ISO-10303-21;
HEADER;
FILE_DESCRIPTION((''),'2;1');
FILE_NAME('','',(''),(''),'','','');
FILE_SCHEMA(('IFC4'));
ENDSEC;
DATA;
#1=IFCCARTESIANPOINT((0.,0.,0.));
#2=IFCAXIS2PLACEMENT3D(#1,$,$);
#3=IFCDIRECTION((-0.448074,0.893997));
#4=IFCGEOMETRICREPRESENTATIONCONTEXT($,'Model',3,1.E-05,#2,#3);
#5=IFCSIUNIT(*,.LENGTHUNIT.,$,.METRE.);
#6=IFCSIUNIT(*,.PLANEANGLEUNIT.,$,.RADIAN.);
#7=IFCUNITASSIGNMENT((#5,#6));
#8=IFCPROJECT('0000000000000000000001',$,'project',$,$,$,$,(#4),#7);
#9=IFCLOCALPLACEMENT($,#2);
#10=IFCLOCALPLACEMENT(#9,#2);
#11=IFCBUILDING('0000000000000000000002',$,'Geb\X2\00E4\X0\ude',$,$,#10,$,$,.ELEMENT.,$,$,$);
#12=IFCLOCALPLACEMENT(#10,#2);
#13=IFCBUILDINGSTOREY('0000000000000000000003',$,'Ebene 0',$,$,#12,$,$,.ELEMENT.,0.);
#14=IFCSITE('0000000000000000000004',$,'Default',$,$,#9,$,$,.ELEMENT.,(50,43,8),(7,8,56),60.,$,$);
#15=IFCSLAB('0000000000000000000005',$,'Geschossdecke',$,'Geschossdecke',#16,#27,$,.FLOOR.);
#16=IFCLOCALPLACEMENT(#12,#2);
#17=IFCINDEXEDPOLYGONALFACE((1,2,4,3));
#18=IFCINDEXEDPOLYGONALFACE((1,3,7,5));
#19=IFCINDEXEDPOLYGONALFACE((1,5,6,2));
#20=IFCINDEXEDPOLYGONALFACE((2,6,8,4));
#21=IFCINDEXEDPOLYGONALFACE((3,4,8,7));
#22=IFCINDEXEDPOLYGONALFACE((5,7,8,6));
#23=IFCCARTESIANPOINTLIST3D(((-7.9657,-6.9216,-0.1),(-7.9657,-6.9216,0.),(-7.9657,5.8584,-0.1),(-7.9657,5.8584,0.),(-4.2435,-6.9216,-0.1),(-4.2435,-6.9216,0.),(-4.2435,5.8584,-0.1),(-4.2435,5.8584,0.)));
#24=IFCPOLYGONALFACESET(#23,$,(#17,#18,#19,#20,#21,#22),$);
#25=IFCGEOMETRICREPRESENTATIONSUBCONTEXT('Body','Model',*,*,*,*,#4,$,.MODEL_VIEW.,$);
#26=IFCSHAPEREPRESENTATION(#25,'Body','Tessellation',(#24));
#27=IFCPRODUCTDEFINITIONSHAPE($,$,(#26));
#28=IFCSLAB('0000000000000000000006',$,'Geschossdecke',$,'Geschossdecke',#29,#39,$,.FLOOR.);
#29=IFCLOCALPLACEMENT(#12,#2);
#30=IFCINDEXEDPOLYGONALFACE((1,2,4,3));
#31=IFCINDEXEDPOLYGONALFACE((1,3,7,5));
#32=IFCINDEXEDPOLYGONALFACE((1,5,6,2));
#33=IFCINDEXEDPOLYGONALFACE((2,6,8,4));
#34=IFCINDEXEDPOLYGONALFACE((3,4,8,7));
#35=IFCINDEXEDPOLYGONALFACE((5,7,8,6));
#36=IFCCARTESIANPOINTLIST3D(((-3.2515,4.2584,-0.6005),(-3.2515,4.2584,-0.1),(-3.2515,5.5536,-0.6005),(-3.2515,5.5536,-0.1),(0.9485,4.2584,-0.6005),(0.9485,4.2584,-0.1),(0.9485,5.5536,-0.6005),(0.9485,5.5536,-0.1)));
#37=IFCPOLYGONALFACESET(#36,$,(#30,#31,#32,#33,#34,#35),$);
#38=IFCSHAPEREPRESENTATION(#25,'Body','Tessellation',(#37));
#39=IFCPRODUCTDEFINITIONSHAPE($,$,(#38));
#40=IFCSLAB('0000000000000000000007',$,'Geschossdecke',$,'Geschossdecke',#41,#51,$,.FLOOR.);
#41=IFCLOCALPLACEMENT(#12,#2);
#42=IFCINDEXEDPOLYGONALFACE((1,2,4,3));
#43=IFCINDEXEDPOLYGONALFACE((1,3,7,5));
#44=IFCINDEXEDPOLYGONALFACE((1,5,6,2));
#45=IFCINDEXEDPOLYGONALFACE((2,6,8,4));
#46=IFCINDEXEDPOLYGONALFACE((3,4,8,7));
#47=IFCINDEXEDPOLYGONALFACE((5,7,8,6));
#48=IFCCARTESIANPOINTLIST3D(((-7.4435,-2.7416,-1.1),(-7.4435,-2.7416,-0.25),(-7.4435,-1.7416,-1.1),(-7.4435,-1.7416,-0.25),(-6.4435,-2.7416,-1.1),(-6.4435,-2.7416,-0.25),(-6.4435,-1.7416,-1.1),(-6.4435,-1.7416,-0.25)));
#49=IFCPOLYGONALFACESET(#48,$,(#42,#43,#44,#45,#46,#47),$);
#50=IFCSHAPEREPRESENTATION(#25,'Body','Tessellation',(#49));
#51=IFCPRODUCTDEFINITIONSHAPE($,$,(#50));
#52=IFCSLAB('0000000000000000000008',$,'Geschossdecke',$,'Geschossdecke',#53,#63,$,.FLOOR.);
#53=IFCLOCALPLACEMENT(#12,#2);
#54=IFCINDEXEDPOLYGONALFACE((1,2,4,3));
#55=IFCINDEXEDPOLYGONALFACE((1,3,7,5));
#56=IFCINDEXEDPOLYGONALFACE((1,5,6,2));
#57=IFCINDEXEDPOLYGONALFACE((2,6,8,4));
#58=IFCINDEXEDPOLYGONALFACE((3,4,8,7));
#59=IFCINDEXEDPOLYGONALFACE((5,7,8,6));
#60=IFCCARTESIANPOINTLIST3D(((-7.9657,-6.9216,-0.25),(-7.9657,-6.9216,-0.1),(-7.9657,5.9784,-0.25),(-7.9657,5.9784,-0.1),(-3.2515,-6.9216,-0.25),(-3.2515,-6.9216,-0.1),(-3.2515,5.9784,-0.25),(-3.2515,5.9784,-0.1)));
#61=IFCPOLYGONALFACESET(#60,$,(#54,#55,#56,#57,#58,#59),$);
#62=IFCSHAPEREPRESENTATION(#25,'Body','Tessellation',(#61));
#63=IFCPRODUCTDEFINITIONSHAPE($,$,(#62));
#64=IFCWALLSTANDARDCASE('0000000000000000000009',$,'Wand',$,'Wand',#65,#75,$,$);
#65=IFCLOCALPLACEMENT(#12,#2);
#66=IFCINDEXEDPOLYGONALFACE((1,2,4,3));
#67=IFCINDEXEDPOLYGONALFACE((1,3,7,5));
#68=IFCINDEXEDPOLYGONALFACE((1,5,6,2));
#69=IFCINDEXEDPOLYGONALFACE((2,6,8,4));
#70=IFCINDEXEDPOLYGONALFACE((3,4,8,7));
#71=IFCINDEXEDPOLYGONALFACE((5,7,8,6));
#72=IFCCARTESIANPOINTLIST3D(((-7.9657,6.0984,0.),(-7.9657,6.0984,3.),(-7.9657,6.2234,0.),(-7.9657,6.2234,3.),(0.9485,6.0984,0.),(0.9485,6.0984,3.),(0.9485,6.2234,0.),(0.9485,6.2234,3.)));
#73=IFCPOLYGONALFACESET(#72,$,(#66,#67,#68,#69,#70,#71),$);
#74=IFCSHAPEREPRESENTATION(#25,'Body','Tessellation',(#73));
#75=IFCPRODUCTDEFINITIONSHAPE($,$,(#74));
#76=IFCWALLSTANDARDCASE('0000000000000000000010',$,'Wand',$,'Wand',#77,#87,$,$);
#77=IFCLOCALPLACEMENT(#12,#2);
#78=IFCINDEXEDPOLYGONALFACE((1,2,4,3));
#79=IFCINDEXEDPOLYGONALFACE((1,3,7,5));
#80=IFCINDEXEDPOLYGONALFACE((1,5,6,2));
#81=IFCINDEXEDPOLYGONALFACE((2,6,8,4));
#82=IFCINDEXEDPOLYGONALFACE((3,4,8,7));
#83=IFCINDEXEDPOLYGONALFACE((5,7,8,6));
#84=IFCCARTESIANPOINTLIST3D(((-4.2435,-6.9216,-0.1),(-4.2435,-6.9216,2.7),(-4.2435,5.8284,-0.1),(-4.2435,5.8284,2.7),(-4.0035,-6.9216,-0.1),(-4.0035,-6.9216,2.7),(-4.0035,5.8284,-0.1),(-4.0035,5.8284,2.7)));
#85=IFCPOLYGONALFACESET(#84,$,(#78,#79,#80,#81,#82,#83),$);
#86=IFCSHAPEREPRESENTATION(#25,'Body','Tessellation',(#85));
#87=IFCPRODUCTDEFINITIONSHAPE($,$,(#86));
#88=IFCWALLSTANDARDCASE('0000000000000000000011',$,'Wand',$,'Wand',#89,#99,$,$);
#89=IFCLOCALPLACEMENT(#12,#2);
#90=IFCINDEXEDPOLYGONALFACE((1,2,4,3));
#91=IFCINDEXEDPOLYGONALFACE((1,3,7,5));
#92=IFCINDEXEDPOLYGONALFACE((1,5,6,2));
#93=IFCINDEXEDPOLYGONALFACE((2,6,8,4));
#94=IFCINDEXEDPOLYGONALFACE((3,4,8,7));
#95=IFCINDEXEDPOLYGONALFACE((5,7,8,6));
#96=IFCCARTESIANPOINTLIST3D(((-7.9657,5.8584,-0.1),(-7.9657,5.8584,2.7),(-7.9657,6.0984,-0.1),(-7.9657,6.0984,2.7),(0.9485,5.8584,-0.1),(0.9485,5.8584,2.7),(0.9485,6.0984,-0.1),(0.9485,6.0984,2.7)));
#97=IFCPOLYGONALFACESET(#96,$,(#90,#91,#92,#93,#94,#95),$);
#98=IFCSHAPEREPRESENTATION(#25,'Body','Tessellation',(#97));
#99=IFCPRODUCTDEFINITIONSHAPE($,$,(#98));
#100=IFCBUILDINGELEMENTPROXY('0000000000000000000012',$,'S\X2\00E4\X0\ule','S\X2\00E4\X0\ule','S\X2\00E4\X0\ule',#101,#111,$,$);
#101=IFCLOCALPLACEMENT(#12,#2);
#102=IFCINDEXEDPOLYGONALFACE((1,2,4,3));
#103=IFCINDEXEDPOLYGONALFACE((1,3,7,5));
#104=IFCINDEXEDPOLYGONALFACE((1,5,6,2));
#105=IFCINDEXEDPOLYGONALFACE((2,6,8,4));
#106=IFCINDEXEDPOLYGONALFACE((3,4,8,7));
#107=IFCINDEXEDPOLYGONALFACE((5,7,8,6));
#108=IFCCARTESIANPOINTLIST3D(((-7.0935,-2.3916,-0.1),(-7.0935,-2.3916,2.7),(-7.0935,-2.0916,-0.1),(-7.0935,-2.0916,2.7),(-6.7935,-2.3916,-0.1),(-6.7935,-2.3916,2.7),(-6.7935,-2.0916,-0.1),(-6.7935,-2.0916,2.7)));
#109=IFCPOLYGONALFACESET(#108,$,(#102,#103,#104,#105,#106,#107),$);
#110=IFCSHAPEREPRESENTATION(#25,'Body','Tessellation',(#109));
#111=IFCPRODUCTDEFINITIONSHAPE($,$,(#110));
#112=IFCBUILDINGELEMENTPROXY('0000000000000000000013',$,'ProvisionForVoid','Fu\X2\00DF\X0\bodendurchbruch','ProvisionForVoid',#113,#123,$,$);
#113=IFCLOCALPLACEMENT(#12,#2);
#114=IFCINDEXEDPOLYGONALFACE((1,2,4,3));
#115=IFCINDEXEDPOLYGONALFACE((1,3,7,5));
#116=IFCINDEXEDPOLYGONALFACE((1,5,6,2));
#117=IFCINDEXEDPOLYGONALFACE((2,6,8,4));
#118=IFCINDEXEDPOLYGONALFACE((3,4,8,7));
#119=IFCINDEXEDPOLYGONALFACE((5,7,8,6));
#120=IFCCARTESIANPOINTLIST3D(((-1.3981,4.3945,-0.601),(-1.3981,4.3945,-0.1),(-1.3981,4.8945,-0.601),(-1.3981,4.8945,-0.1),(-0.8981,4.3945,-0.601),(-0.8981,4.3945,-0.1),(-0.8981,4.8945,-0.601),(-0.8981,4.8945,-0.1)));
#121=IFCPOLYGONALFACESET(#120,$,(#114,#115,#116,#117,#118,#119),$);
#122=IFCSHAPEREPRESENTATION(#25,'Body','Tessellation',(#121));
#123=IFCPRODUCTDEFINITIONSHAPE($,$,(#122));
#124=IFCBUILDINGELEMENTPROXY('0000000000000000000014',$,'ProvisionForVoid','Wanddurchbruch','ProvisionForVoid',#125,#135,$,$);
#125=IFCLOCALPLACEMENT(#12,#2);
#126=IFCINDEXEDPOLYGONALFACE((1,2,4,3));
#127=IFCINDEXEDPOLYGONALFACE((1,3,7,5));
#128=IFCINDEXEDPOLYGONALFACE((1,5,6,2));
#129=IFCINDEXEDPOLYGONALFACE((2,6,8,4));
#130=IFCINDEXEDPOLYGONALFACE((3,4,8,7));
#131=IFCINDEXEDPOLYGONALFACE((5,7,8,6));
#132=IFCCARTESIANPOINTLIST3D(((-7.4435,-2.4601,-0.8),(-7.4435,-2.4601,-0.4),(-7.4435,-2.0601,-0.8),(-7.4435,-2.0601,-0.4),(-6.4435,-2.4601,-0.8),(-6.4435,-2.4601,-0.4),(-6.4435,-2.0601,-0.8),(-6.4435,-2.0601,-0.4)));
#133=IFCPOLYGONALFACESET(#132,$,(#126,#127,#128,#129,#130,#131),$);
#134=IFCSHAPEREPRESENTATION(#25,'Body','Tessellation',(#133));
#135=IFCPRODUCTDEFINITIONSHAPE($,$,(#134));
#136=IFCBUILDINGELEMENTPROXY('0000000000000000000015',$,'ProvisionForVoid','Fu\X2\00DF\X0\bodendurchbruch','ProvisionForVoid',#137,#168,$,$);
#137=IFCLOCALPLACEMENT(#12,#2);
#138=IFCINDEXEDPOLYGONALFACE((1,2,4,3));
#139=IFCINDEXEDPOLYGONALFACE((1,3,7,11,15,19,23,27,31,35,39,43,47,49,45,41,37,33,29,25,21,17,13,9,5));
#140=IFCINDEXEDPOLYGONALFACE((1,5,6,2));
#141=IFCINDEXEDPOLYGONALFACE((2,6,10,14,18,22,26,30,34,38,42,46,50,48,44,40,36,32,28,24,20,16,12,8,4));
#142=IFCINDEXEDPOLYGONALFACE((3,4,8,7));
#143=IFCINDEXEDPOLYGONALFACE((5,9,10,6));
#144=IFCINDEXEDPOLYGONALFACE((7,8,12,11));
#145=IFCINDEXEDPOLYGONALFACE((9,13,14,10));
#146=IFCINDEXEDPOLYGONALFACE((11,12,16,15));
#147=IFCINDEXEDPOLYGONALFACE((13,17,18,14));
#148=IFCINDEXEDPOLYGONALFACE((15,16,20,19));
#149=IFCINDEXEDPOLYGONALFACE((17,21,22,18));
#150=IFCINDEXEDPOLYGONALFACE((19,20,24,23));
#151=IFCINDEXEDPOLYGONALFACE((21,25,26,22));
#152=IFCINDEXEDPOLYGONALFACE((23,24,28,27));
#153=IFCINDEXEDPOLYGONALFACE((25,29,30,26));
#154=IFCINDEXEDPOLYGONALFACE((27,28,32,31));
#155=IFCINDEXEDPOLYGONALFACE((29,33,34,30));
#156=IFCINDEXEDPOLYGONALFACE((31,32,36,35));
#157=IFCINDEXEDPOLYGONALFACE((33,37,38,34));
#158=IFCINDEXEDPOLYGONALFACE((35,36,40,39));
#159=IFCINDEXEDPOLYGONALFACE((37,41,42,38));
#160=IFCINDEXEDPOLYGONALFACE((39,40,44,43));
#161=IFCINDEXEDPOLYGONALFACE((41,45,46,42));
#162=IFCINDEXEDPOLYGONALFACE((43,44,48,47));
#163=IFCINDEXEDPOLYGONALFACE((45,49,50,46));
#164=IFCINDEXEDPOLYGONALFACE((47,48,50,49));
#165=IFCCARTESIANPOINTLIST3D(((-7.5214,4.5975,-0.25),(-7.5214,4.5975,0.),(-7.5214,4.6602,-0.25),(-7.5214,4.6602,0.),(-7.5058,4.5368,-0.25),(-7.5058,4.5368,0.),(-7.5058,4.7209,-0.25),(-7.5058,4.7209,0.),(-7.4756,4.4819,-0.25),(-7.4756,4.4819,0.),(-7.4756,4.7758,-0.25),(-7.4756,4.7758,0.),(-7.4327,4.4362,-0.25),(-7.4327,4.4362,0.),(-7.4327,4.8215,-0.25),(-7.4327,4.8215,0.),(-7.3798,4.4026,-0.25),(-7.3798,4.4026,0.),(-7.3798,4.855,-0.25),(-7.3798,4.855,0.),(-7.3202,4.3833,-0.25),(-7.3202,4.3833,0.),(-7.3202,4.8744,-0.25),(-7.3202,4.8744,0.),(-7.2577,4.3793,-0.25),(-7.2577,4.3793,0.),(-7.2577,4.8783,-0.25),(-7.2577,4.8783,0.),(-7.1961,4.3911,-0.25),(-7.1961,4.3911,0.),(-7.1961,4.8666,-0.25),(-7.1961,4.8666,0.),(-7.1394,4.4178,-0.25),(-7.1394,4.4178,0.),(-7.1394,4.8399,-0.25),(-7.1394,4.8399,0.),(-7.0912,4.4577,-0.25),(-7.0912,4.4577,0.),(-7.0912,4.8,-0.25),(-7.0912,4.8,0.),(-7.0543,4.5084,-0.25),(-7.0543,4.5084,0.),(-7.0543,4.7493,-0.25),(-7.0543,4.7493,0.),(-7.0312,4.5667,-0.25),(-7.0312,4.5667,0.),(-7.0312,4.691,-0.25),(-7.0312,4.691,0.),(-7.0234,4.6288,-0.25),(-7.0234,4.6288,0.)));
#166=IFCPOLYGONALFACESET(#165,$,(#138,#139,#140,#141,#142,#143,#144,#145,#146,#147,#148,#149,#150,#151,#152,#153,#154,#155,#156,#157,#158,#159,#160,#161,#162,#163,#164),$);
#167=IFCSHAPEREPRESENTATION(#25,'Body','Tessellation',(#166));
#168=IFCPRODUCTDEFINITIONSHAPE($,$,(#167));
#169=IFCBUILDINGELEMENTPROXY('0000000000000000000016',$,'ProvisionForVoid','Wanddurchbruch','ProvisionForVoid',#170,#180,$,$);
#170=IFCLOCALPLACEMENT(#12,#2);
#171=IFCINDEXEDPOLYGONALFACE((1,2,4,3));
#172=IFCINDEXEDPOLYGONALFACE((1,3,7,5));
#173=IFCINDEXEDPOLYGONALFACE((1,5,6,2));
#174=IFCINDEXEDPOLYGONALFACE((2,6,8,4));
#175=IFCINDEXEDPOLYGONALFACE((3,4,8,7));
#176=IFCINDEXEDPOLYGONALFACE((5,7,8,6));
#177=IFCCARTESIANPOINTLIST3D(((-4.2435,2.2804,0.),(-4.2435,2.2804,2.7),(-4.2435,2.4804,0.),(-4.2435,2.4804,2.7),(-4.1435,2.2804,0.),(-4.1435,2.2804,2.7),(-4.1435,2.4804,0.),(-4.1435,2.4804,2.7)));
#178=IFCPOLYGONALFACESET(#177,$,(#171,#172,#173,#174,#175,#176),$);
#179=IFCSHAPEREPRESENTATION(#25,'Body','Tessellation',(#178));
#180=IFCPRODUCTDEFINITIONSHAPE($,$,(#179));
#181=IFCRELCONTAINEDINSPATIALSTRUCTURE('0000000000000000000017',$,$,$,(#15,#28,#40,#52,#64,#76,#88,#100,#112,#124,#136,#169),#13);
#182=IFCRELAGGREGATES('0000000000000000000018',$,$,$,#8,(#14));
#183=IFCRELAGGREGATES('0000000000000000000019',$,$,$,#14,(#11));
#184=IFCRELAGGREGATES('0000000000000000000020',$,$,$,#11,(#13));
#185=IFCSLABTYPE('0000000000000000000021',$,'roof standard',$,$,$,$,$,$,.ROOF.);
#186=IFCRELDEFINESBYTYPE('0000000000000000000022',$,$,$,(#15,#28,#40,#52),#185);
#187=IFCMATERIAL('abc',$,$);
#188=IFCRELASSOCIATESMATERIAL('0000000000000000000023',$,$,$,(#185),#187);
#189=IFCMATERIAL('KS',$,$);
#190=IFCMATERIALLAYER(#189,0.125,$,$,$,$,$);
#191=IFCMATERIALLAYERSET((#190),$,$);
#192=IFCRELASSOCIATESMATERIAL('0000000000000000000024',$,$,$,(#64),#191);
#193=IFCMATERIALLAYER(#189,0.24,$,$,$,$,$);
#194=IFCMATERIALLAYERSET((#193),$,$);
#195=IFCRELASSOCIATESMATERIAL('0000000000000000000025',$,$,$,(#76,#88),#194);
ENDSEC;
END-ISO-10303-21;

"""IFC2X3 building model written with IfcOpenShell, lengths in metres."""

from ifc_helpers import new_model, si_unit, direction, frame, frame_2d, origin, place, context, subcontext, project, spatial, polyline, rectangle, circle, extrude, clip, bounded_halfspace, material, layer, layer_set, layer_usage, type_object, element, save


model = new_model("IFC2X3")

# Units and contexts
model_context = context("Model", 3, precision=1e-05, world=origin(), true_north=direction((-0.448074, 0.893997)))
body_context = subcontext(model_context, "Body", "Model", "MODEL_VIEW")
ifc_project = project(units=[si_unit("LENGTHUNIT", "METRE"), si_unit("PLANEANGLEUNIT", "RADIAN")], contexts=[model_context])

# Site, building, storey
site_placement = place(None, origin())
site = spatial("IfcSite", under=ifc_project, at=site_placement, Name="Default", CompositionType="ELEMENT", RefLatitude=(50, 43, 8), RefLongitude=(7, 8, 56), RefElevation=60.0)
building_placement = place(site_placement, origin())
building = spatial("IfcBuilding", under=site, at=building_placement, Name="Gebäude", CompositionType="ELEMENT")
storey_placement = place(building_placement, origin())
storey = spatial("IfcBuildingStorey", under=building, at=storey_placement, Name="Ebene 0", CompositionType="ELEMENT", Elevation=0.0)

# Slabs
ifc_material_1 = material(Name="abc")
slab_type = type_object("IfcSlabType", Name="roof standard", PredefinedType="ROOF", material=ifc_material_1)
slab_1_placement = place(storey_placement, origin())
element("IfcSlab", 1, at=slab_1_placement, inside=storey, type_object=slab_type, Name="Geschossdecke", ObjectType="Geschossdecke", PredefinedType="FLOOR", context=body_context, shape_type="SweptSolid", body=[
    extrude(rectangle(XDim=12.78, YDim=3.7222, at=frame_2d((0.0, 0.0), x_axis=(0.0, 1.0))), frame((-6.1046, -0.5316, -0.1)), (0.0, 0.0, 1.0), 0.1),
])
slab_2_placement = place(storey_placement, frame((0.0, 0.0, -0.1)))
element("IfcSlab", 2, at=slab_2_placement, inside=storey, type_object=slab_type, Name="Geschossdecke", ObjectType="Geschossdecke", PredefinedType="FLOOR", context=body_context, shape_type="SweptSolid", body=[
    extrude(rectangle(XDim=4.2, YDim=1.2952, at=frame_2d((0.0, 0.0), x_axis=(1.0, 0.0))), frame((-1.1515, 4.906, -0.5005)), (0.0, 0.0, 1.0), 0.5005),
])
slab_3_placement = place(storey_placement, frame((0.0, 0.0, -0.25)))
element("IfcSlab", 3, at=slab_3_placement, inside=storey, type_object=slab_type, Name="Geschossdecke", ObjectType="Geschossdecke", PredefinedType="FLOOR", context=body_context, shape_type="SweptSolid", body=[
    extrude(rectangle(XDim=1.0, YDim=1.0, at=frame_2d((0.0, 0.0), x_axis=(-1.0, 0.0))), frame((-6.9435, -2.2416, -0.85)), (0.0, 0.0, 1.0), 0.85),
])
slab_4_placement = place(storey_placement, frame((0.0, 0.0, -0.1)))
element("IfcSlab", 4, at=slab_4_placement, inside=storey, type_object=slab_type, Name="Geschossdecke", ObjectType="Geschossdecke", PredefinedType="FLOOR", context=body_context, shape_type="SweptSolid", body=[
    extrude(rectangle(XDim=4.7141, YDim=12.9, at=frame_2d((0.0, 0.0), x_axis=(1.0, 0.0))), frame((-5.6086, -0.4716, -0.15)), (0.0, 0.0, 1.0), 0.15),
])

# Walls
ifc_material_2 = material(Name="KS")
ifc_layer_1 = layer(ifc_material_2, 0.125)
ifc_layer_set_1 = layer_set([ifc_layer_1])
ifc_layer_usage_1 = layer_usage(ifc_layer_set_1, "AXIS2", "POSITIVE", -0.0625)
wall_1_placement = place(storey_placement, frame((-7.9657, 6.1609, 0.0)))
element("IfcWallStandardCase", 5, at=wall_1_placement, inside=storey, material=ifc_layer_usage_1, Name="Wand", ObjectType="Wand", context=body_context, shape_type="Clipping", body=[
    clip(clip(extrude(rectangle(XDim=8.9141, YDim=0.125, at=frame_2d((0.0, 0.0), x_axis=(1.0, 0.0))), frame((4.4571, 0.0, 0.0)), (0.0, 0.0, 1.0), 3.0), bounded_halfspace(frame((0.0, -0.0625, 3.0)), False, origin(), polyline([(0.0, -0.0625), (8.9141, -0.0625), (8.9141, 0.0625), (0.0, 0.0625), (0.0, -0.0625)]))), bounded_halfspace(frame((0.0, 0.0625, 0.0), z_axis=(0.0, 0.0, -1.0), x_axis=(1.0, 0.0, 0.0)), False, origin(), polyline([(0.0, 0.0625), (8.9141, 0.0625), (8.9141, -0.0625), (0.0, -0.0625), (0.0, 0.0625)]))),
])
ifc_layer_2 = layer(ifc_material_2, 0.24)
ifc_layer_set_2 = layer_set([ifc_layer_2])
ifc_layer_usage_2 = layer_usage(ifc_layer_set_2, "AXIS2", "POSITIVE", -0.12)
wall_2_placement = place(storey_placement, frame((-4.1235, 5.8284, 0.0), z_axis=(0.0, 0.0, 1.0), x_axis=(0.0, -1.0, 0.0)))
element("IfcWallStandardCase", 6, at=wall_2_placement, inside=storey, material=ifc_layer_usage_2, Name="Wand", ObjectType="Wand", context=body_context, shape_type="Clipping", body=[
    clip(clip(extrude(rectangle(XDim=12.75, YDim=0.24, at=frame_2d((0.0, 0.0), x_axis=(0.0, -1.0))), frame((6.375, 0.0, -0.1), z_axis=(0.0, 0.0, 1.0), x_axis=(0.0, 1.0, 0.0)), (0.0, 0.0, 1.0), 2.8), bounded_halfspace(frame((0.0, -0.12, 2.7)), False, origin(), polyline([(0.0, -0.12), (12.75, -0.12), (12.75, 0.12), (0.0, 0.12), (0.0, -0.12)]))), bounded_halfspace(frame((0.0, 0.12, -0.1), z_axis=(0.0, 0.0, -1.0), x_axis=(1.0, 0.0, 0.0)), False, origin(), polyline([(0.0, 0.12), (12.75, 0.12), (12.75, -0.12), (0.0, -0.12), (0.0, 0.12)]))),
])
wall_3_placement = place(storey_placement, frame((-7.9657, 5.9784, 0.0)))
element("IfcWallStandardCase", 7, at=wall_3_placement, inside=storey, material=ifc_layer_usage_2, Name="Wand", ObjectType="Wand", context=body_context, shape_type="Clipping", body=[
    clip(clip(extrude(rectangle(XDim=8.9141, YDim=0.24, at=frame_2d((0.0, 0.0), x_axis=(1.0, 0.0))), frame((4.4571, 0.0, -0.1)), (0.0, 0.0, 1.0), 2.8), bounded_halfspace(frame((0.0, -0.12, 2.7)), False, origin(), polyline([(0.0, -0.12), (8.9141, -0.12), (8.9141, 0.12), (0.0, 0.12), (0.0, -0.12)]))), bounded_halfspace(frame((0.0, 0.12, -0.1), z_axis=(0.0, 0.0, -1.0), x_axis=(1.0, 0.0, 0.0)), False, origin(), polyline([(0.0, 0.12), (8.9141, 0.12), (8.9141, -0.12), (0.0, -0.12), (0.0, 0.12)]))),
])

# Building element proxies
proxy_1_placement = place(storey_placement, origin())
element("IfcBuildingElementProxy", 8, at=proxy_1_placement, inside=storey, Name="Säule", Description="Säule", ObjectType="Säule", context=body_context, shape_type="SweptSolid", body=[
    extrude(rectangle(XDim=0.3, YDim=0.3, at=frame_2d((0.0, 0.0), x_axis=(0.0, -1.0))), frame((-6.9435, -2.2416, -0.1)), (0.0, 0.0, 1.0), 2.8),
])
proxy_2_placement = place(storey_placement, origin())
element("IfcBuildingElementProxy", 9, at=proxy_2_placement, inside=storey, Name="ProvisionForVoid", Description="Fußbodendurchbruch", ObjectType="ProvisionForVoid", context=body_context, shape_type="SweptSolid", body=[
    extrude(rectangle(XDim=0.5, YDim=0.501, at=frame_2d((0.0, 0.0), x_axis=(1.0, 0.0))), frame((-1.3981, 4.6445, -0.3505), z_axis=(1.0, 0.0, 0.0), x_axis=(0.0, 1.0, 0.0)), (0.0, 0.0, 1.0), 0.5),
])
proxy_3_placement = place(storey_placement, origin())
element("IfcBuildingElementProxy", 10, at=proxy_3_placement, inside=storey, Name="ProvisionForVoid", Description="Wanddurchbruch", ObjectType="ProvisionForVoid", context=body_context, shape_type="SweptSolid", body=[
    extrude(rectangle(XDim=0.4, YDim=0.4, at=frame_2d((0.0, 0.0), x_axis=(1.0, 0.0))), frame((-7.4435, -2.2601, -0.6), z_axis=(1.0, 0.0, 0.0), x_axis=(0.0, 1.0, 0.0)), (0.0, 0.0, 1.0), 1.0),
])
proxy_4_placement = place(storey_placement, origin())
element("IfcBuildingElementProxy", 11, at=proxy_4_placement, inside=storey, Name="ProvisionForVoid", Description="Fußbodendurchbruch", ObjectType="ProvisionForVoid", context=body_context, shape_type="SweptSolid", body=[
    extrude(circle(Radius=0.25, at=frame_2d((0.0, 0.0), x_axis=(1.0, 0.0))), frame((-7.2734, 4.6288, -0.25)), (0.0, 0.0, 1.0), 0.25),
])
proxy_5_placement = place(storey_placement, origin())
element("IfcBuildingElementProxy", 12, at=proxy_5_placement, inside=storey, Name="ProvisionForVoid", Description="Wanddurchbruch", ObjectType="ProvisionForVoid", context=body_context, shape_type="SweptSolid", body=[
    extrude(rectangle(XDim=0.2, YDim=2.7, at=frame_2d((0.0, 0.0), x_axis=(1.0, 0.0))), frame((-4.2435, 2.3804, 1.35), z_axis=(1.0, 0.0, 0.0), x_axis=(0.0, 1.0, 0.0)), (0.0, 0.0, 1.0), 0.1),
])

save(model, "model.ifc")
